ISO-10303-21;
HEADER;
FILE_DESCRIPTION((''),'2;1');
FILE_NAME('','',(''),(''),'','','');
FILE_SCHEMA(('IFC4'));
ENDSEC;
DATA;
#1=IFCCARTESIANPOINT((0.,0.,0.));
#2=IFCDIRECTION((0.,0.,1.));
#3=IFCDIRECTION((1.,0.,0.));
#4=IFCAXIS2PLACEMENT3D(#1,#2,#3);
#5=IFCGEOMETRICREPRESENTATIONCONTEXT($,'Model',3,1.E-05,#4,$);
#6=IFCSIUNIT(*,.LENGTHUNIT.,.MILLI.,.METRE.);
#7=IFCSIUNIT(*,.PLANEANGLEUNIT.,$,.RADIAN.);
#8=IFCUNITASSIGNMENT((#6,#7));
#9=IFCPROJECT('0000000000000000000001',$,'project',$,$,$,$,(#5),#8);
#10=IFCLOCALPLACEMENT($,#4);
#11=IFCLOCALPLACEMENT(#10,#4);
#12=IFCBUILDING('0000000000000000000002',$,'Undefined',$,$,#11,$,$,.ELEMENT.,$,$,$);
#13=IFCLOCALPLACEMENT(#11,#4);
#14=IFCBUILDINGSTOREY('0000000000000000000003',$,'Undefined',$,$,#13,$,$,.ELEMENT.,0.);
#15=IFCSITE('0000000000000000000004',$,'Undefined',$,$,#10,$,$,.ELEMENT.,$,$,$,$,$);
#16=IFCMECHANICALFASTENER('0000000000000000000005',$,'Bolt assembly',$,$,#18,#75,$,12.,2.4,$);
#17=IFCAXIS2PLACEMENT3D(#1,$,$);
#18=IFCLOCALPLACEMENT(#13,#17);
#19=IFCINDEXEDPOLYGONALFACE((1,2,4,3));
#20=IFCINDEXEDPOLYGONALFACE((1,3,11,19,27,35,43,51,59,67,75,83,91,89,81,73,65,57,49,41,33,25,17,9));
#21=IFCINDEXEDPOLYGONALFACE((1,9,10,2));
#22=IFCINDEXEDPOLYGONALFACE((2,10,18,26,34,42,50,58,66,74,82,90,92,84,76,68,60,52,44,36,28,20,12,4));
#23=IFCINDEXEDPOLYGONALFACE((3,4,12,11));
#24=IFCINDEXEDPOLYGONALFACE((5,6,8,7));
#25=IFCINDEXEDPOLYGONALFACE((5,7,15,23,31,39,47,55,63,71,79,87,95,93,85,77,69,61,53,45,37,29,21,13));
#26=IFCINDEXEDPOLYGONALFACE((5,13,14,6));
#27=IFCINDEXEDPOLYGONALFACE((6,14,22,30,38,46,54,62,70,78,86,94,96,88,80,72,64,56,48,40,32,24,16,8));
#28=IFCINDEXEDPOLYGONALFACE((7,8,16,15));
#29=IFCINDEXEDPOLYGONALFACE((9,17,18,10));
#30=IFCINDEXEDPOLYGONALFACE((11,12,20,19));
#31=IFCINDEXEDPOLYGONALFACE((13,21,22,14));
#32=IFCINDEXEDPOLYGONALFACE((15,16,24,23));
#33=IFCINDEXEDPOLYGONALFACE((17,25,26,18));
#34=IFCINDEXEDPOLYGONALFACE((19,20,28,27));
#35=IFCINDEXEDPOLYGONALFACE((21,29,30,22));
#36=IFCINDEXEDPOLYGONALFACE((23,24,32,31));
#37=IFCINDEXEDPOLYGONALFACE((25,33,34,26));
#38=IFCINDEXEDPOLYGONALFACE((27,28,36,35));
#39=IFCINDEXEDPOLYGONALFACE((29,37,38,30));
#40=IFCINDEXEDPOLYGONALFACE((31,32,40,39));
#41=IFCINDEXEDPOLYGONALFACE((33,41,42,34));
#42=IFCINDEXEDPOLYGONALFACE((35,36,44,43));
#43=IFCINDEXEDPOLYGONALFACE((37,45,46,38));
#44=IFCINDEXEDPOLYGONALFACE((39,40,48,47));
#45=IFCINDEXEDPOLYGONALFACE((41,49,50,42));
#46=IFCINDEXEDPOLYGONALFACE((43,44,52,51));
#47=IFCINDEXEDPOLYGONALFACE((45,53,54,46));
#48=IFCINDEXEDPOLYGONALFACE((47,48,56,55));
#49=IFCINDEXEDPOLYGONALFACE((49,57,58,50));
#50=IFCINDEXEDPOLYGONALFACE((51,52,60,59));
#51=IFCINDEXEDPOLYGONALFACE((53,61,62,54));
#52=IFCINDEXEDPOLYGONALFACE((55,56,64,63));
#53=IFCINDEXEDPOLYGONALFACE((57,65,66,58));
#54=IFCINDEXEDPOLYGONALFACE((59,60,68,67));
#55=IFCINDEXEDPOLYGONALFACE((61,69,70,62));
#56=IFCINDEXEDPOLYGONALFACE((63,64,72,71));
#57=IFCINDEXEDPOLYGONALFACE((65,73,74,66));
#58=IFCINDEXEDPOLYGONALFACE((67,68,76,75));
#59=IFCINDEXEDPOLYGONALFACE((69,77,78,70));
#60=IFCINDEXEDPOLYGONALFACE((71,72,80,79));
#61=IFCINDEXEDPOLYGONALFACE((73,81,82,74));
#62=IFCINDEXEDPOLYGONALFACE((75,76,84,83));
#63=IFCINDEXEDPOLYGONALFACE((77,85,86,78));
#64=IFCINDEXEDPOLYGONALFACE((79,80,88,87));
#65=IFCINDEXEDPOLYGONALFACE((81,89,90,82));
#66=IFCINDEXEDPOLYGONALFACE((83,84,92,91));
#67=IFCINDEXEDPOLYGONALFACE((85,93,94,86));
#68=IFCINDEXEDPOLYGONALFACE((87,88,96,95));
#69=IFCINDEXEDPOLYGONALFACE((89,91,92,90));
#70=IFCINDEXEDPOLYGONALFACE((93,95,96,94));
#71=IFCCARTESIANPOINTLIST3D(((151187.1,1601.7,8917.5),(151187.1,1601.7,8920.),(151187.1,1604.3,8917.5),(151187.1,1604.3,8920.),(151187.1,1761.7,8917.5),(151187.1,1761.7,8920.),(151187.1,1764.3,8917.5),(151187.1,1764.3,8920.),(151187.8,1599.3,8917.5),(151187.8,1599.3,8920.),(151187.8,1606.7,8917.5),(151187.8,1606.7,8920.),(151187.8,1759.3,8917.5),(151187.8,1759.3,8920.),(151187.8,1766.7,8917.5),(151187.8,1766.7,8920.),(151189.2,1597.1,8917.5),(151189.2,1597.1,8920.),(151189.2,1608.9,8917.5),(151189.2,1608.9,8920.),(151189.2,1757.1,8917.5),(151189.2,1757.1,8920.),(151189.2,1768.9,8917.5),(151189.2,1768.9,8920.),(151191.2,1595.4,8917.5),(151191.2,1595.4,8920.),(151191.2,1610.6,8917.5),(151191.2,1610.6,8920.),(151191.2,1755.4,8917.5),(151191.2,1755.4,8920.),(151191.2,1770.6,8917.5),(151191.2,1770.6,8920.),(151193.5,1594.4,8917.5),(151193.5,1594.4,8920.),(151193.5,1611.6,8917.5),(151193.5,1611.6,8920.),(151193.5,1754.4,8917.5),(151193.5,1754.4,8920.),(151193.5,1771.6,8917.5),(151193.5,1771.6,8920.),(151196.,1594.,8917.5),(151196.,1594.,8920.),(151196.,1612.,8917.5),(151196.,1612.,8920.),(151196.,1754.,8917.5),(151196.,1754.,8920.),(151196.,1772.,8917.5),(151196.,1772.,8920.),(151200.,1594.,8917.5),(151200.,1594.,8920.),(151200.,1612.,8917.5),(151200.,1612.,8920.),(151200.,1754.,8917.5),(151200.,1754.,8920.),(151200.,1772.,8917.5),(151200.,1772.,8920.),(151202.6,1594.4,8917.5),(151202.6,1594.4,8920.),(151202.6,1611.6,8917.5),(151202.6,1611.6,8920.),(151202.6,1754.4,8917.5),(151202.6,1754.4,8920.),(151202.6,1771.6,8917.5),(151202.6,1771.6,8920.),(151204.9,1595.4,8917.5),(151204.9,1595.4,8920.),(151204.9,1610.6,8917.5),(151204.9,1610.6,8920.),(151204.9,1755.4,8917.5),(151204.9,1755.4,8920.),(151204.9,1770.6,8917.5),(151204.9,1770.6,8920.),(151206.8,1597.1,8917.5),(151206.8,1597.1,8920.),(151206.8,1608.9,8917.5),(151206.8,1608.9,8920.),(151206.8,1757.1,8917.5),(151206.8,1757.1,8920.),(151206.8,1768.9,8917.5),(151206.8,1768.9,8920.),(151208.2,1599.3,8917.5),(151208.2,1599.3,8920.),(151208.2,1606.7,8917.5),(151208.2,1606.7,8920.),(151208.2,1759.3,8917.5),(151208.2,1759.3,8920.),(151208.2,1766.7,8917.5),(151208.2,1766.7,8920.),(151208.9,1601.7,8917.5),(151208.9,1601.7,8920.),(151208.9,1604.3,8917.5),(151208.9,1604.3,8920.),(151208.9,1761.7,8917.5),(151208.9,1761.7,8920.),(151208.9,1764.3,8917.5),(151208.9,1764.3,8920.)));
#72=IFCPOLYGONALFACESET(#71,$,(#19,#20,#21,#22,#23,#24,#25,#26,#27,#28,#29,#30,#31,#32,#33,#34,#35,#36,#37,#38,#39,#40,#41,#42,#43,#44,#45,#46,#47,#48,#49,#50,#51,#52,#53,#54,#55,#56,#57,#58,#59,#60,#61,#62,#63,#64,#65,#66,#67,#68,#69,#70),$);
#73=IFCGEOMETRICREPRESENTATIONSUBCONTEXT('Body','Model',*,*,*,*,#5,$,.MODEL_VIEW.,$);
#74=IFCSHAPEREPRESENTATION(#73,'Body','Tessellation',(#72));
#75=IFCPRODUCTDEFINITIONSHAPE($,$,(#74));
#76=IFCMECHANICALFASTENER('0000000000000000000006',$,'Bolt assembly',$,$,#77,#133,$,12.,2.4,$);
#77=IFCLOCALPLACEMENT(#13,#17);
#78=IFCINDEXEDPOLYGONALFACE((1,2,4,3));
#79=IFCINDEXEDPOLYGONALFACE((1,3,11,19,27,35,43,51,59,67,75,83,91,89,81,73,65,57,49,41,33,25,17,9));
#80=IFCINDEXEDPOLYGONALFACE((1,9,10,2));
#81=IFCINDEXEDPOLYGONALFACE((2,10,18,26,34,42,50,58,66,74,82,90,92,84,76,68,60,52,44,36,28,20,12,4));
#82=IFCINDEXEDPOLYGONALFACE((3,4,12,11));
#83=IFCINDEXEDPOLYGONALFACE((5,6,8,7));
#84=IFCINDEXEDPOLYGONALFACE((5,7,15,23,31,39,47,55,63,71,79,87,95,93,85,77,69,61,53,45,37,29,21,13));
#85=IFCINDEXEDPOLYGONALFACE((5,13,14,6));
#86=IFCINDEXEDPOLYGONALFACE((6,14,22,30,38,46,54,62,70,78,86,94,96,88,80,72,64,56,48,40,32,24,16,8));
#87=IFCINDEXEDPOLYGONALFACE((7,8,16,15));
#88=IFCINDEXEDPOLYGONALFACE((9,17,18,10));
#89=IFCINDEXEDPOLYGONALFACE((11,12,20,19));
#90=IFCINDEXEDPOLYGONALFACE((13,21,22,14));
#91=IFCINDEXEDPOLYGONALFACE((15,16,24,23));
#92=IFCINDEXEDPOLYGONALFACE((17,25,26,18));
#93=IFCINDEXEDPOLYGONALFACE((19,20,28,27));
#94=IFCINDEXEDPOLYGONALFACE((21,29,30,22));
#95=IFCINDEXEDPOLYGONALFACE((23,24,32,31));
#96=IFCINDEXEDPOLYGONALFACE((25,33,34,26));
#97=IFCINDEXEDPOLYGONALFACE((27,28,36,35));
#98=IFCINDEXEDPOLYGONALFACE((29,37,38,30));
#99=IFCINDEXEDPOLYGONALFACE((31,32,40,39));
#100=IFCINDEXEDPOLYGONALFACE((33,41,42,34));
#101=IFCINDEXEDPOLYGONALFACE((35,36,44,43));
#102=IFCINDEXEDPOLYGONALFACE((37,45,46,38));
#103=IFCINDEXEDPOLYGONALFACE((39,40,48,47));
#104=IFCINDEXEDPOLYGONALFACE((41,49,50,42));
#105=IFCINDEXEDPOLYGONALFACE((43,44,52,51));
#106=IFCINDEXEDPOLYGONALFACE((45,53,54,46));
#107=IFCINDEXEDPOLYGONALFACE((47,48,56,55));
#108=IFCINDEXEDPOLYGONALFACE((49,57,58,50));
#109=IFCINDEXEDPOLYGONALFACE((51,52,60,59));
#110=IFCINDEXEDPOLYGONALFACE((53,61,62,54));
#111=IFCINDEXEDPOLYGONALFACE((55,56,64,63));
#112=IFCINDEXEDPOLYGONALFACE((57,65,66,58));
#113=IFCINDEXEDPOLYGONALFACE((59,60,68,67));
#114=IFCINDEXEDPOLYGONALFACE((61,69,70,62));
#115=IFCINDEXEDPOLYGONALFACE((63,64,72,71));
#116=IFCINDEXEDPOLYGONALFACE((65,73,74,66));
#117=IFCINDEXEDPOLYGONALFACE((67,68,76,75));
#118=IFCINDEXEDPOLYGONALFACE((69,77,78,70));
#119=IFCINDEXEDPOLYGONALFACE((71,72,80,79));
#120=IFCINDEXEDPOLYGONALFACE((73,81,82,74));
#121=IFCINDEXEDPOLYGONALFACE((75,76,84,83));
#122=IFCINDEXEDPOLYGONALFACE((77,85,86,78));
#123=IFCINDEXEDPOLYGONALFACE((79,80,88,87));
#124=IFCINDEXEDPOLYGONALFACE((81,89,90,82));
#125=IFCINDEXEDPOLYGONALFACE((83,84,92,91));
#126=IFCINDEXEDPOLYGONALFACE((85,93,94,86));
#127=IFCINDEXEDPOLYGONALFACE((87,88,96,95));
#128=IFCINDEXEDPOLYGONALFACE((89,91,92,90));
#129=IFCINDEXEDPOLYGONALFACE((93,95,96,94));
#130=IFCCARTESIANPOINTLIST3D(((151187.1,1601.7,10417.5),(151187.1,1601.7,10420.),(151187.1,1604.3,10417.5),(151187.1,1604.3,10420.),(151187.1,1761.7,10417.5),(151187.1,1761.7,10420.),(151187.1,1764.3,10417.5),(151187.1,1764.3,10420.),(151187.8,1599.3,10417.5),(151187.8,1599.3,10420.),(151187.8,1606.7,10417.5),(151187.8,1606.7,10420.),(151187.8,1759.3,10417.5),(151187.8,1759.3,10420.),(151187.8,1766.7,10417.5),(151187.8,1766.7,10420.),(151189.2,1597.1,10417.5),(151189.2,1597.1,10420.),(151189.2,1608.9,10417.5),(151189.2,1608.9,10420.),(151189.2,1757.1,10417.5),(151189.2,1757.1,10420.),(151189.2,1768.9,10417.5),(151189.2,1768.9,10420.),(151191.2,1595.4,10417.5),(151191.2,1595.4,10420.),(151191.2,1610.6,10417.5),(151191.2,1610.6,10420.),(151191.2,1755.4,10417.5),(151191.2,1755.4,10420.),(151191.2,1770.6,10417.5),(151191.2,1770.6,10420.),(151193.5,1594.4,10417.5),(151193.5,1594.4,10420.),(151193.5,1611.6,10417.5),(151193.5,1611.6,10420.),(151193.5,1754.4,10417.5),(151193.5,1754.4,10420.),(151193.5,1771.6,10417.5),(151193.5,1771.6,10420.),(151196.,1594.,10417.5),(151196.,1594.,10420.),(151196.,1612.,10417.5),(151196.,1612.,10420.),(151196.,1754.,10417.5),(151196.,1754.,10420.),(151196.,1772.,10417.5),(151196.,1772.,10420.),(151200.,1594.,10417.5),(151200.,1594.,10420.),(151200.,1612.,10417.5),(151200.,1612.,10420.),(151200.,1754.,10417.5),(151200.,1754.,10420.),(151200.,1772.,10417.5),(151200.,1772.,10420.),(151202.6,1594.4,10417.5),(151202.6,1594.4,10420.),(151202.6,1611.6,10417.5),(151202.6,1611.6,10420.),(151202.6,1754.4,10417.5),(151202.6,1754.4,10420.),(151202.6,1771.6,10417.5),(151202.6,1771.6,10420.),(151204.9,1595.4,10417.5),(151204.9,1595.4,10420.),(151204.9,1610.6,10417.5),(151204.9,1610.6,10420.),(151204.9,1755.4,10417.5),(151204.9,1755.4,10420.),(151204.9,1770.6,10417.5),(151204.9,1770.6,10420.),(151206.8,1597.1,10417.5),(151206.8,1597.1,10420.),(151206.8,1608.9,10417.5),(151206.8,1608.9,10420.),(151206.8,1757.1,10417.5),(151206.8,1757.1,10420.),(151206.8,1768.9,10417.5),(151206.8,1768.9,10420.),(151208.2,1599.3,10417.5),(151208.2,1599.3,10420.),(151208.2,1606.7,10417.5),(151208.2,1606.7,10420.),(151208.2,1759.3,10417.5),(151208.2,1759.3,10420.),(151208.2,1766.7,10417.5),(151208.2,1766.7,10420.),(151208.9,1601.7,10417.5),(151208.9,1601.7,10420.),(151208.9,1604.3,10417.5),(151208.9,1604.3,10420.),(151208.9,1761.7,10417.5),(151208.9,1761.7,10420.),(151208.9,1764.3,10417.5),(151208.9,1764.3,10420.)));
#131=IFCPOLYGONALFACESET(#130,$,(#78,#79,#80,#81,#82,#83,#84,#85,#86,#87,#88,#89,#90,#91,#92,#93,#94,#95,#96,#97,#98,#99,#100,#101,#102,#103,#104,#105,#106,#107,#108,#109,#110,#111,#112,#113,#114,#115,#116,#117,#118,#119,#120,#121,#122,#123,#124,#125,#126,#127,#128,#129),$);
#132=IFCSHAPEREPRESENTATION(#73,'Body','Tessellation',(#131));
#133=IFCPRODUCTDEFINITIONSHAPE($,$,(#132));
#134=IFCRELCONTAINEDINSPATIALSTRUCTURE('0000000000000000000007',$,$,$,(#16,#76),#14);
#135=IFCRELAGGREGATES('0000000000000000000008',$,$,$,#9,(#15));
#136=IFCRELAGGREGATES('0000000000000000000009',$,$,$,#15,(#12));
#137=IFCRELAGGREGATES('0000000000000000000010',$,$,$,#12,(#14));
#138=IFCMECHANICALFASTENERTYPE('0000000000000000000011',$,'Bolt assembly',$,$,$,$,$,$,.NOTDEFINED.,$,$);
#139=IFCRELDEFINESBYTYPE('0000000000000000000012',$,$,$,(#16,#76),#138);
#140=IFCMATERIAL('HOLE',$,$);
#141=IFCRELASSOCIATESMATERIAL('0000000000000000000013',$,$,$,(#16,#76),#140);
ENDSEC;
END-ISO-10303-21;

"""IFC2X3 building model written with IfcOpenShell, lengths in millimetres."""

from ifc_helpers import new_model, si_unit, frame, frame_2d, origin_with_axes, place, context, subcontext, project, spatial, polyline, circle_curve, parameter, trimmed, segment, composite_curve, outline, extrude, source, transform, mapped, material, type_object, element, save


model = new_model("IFC2X3")

# Units and contexts
model_context = context("Model", 3, precision=1e-05, world=origin_with_axes())
body_context = subcontext(model_context, "Body", "Model", "MODEL_VIEW")
ifc_project = project(units=[si_unit("LENGTHUNIT", "METRE", prefix="MILLI"), si_unit("PLANEANGLEUNIT", "RADIAN")], contexts=[model_context])

# Site, building, storey
site_placement = place(None, origin_with_axes())
site = spatial("IfcSite", under=ifc_project, at=site_placement, Name="Undefined", CompositionType="ELEMENT")
building_placement = place(site_placement, origin_with_axes())
building = spatial("IfcBuilding", under=site, at=building_placement, Name="Undefined", CompositionType="ELEMENT")
storey_placement = place(building_placement, origin_with_axes())
storey = spatial("IfcBuildingStorey", under=building, at=storey_placement, Name="Undefined", CompositionType="ELEMENT", Elevation=0.0)

# Mechanical fasteners
ifc_material_1 = material(Name="HOLE")
mechanical_fastener_type = type_object("IfcMechanicalFastenerType", Name="Bolt assembly")
shared_shape_1 = source(origin_with_axes(), body_context, "Body", "SweptSolid", [
    extrude(outline(composite_curve([segment(polyline([(-2.0, 9.0), (2.0, 9.0)]), True, "CONTINUOUS"), segment(trimmed(circle_curve(frame_2d((2.0, 0.0), x_axis=(0.0, 1.0)), 9.0), [parameter(0.0)], [parameter(3.141593)], False, "PARAMETER"), True, "CONTINUOUS"), segment(polyline([(2.0, -9.0), (-2.0, -9.0)]), True, "CONTINUOUS"), segment(trimmed(circle_curve(frame_2d((-2.0, 0.0), x_axis=(0.0, -1.0)), 9.0), [parameter(0.0)], [parameter(3.141593)], False, "PARAMETER"), True, "DISCONTINUOUS")], self_intersect=False)), frame((0.0, -2.4, 0.0), z_axis=(0.0, 1.0, 0.0), x_axis=(1.0, 0.0, 0.0)), (0.0, 0.0, 1.0), 2.5),
])
mechanical_fastener_1_placement = place(storey_placement, frame((151198.0, 1683.0, 8917.6), z_axis=(0.0, -1.0, 0.0), x_axis=(-1.0, 0.0, 0.0)))
element("IfcMechanicalFastener", 1, at=mechanical_fastener_1_placement, inside=storey, type_object=mechanical_fastener_type, material=ifc_material_1, Name="Bolt assembly", NominalDiameter=12.0, NominalLength=2.4, context=body_context, shape_type="MappedRepresentation", body=[
    mapped(shared_shape_1, transform((0.0, 0.0, -80.0))),
    mapped(shared_shape_1, transform((0.0, 0.0, 80.0))),
])
shared_shape_2 = source(origin_with_axes(), body_context, "Body", "SweptSolid", [
    extrude(outline(composite_curve([segment(polyline([(-2.0, 9.0), (2.0, 9.0)]), True, "CONTINUOUS"), segment(trimmed(circle_curve(frame_2d((2.0, 0.0), x_axis=(0.0, 1.0)), 9.0), [parameter(0.0)], [parameter(3.141593)], False, "PARAMETER"), True, "CONTINUOUS"), segment(polyline([(2.0, -9.0), (-2.0, -9.0)]), True, "CONTINUOUS"), segment(trimmed(circle_curve(frame_2d((-2.0, 0.0), x_axis=(0.0, -1.0)), 9.0), [parameter(0.0)], [parameter(3.141593)], False, "PARAMETER"), True, "DISCONTINUOUS")], self_intersect=False)), frame((0.0, -2.4, 0.0), z_axis=(0.0, 1.0, 0.0), x_axis=(1.0, 0.0, 0.0)), (0.0, 0.0, 1.0), 2.5),
])
mechanical_fastener_2_placement = place(storey_placement, frame((151198.0, 1683.0, 10417.6), z_axis=(0.0, -1.0, 0.0), x_axis=(-1.0, 0.0, 0.0)))
element("IfcMechanicalFastener", 2, at=mechanical_fastener_2_placement, inside=storey, type_object=mechanical_fastener_type, material=ifc_material_1, Name="Bolt assembly", NominalDiameter=12.0, NominalLength=2.4, context=body_context, shape_type="MappedRepresentation", body=[
    mapped(shared_shape_2, transform((0.0, 0.0, -80.0))),
    mapped(shared_shape_2, transform((0.0, 0.0, 80.0))),
])

save(model, "model.ifc")
